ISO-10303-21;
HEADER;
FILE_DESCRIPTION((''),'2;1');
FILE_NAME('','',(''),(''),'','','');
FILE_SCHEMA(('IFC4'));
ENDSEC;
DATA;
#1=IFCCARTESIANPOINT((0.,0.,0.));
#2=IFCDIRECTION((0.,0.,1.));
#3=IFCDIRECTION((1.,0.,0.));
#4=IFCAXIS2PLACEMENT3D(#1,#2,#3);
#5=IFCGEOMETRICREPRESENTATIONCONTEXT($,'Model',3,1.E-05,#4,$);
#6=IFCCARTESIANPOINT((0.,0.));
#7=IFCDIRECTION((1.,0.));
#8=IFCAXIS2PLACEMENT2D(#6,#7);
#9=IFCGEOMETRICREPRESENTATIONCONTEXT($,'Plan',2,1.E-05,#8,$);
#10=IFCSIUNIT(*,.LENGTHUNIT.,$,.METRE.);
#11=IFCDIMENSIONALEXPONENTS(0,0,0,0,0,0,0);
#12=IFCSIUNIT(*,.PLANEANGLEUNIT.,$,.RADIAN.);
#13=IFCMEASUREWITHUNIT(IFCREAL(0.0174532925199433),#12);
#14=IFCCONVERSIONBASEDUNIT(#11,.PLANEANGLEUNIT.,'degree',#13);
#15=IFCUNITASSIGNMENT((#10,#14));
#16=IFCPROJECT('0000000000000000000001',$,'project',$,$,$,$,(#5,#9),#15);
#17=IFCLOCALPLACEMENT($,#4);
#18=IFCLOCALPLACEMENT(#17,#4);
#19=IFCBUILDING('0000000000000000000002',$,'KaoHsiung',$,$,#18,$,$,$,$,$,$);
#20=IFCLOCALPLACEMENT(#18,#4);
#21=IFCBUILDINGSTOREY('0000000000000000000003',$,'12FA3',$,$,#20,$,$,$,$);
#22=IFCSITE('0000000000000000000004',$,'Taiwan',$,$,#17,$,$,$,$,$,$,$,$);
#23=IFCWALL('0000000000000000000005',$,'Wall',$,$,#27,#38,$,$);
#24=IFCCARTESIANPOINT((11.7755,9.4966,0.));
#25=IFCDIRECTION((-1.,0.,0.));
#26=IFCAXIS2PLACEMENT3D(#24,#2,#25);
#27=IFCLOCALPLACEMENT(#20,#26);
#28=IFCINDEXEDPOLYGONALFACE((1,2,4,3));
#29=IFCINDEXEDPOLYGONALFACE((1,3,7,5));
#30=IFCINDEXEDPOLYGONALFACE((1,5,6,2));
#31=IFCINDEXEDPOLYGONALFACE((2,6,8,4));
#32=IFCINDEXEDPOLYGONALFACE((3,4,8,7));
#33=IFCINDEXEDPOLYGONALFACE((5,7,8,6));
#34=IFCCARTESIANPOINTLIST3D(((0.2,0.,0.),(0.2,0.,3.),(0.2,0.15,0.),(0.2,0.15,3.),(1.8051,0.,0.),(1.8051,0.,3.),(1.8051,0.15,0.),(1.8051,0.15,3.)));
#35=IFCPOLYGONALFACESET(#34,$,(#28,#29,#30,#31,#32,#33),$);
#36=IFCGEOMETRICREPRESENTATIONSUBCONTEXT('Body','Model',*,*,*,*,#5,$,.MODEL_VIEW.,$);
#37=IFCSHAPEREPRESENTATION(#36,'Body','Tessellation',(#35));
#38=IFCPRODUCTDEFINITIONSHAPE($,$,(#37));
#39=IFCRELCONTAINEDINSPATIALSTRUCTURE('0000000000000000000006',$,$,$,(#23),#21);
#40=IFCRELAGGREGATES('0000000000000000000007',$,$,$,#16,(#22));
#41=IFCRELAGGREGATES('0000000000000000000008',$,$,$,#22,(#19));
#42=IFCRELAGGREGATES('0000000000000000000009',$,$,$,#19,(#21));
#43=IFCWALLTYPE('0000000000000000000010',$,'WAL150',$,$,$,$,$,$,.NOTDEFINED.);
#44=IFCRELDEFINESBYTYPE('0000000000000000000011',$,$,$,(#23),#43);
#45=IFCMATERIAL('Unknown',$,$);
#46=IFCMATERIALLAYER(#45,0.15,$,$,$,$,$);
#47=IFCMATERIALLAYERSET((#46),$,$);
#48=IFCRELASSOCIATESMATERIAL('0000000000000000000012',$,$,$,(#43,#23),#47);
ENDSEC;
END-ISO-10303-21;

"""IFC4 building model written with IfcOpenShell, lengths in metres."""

from ifc_helpers import new_model, entity, si_unit, converted_unit, frame, origin_with_axes, origin_2d_with_axis, place, context, subcontext, project, spatial, line, indexed_curve, outline, extrude, material, layer, layer_set, layer_usage, type_object, element, save


model = new_model("IFC4")

# Units and contexts
model_context = context("Model", 3, precision=1e-05, world=origin_with_axes())
plan_context = context("Plan", 2, precision=1e-05, world=origin_2d_with_axis())
body_context_1 = subcontext(model_context, "Body", "Model", "MODEL_VIEW")
ifc_project = project(units=[si_unit("LENGTHUNIT", "METRE"), converted_unit("PLANEANGLEUNIT", "degree", entity("IfcReal", 0.0174532925199433), si_unit("PLANEANGLEUNIT", "RADIAN"), dimensions=[0, 0, 0, 0, 0, 0, 0])], contexts=[model_context, plan_context])

# Site, building, storey
site_placement = place(None, origin_with_axes())
site = spatial("IfcSite", under=ifc_project, at=site_placement, Name="Taiwan")
building_placement = place(site_placement, origin_with_axes())
building = spatial("IfcBuilding", under=site, at=building_placement, Name="KaoHsiung")
storey_placement = place(building_placement, origin_with_axes())
storey = spatial("IfcBuildingStorey", under=building, at=storey_placement, Name="12FA3")

# Shared definitions
ifc_material = material(Name="Unknown")

# Wall
ifc_layer_1 = layer(ifc_material, 0.15)
ifc_layer_set_1 = layer_set([ifc_layer_1])
wall_type_1 = type_object("IfcWallType", Name="WAL150", PredefinedType="NOTDEFINED", material=ifc_layer_set_1)
ifc_layer_usage_1 = layer_usage(ifc_layer_set_1, "AXIS2", "POSITIVE", 0.0)
wall_1_placement = place(storey_placement, frame((11.7755, 9.4966, 0.0), z_axis=(0.0, 0.0, 1.0), x_axis=(-1.0, 0.0, 0.0)))
element("IfcWall", 1, at=wall_1_placement, inside=storey, type_object=wall_type_1, material=ifc_layer_usage_1, Name="Wall", context=body_context_1, shape_type="SweptSolid", body=[
    extrude(outline(indexed_curve([(0.2, 0.0), (0.2, 0.15), (1.8051, 0.15), (1.8051, 0.0)], segments=[line(1, 2, 3, 4, 1)])), origin_with_axes(), (0.0, 0.0, 1.0), 3.0),
])

save(model, "model.ifc")
